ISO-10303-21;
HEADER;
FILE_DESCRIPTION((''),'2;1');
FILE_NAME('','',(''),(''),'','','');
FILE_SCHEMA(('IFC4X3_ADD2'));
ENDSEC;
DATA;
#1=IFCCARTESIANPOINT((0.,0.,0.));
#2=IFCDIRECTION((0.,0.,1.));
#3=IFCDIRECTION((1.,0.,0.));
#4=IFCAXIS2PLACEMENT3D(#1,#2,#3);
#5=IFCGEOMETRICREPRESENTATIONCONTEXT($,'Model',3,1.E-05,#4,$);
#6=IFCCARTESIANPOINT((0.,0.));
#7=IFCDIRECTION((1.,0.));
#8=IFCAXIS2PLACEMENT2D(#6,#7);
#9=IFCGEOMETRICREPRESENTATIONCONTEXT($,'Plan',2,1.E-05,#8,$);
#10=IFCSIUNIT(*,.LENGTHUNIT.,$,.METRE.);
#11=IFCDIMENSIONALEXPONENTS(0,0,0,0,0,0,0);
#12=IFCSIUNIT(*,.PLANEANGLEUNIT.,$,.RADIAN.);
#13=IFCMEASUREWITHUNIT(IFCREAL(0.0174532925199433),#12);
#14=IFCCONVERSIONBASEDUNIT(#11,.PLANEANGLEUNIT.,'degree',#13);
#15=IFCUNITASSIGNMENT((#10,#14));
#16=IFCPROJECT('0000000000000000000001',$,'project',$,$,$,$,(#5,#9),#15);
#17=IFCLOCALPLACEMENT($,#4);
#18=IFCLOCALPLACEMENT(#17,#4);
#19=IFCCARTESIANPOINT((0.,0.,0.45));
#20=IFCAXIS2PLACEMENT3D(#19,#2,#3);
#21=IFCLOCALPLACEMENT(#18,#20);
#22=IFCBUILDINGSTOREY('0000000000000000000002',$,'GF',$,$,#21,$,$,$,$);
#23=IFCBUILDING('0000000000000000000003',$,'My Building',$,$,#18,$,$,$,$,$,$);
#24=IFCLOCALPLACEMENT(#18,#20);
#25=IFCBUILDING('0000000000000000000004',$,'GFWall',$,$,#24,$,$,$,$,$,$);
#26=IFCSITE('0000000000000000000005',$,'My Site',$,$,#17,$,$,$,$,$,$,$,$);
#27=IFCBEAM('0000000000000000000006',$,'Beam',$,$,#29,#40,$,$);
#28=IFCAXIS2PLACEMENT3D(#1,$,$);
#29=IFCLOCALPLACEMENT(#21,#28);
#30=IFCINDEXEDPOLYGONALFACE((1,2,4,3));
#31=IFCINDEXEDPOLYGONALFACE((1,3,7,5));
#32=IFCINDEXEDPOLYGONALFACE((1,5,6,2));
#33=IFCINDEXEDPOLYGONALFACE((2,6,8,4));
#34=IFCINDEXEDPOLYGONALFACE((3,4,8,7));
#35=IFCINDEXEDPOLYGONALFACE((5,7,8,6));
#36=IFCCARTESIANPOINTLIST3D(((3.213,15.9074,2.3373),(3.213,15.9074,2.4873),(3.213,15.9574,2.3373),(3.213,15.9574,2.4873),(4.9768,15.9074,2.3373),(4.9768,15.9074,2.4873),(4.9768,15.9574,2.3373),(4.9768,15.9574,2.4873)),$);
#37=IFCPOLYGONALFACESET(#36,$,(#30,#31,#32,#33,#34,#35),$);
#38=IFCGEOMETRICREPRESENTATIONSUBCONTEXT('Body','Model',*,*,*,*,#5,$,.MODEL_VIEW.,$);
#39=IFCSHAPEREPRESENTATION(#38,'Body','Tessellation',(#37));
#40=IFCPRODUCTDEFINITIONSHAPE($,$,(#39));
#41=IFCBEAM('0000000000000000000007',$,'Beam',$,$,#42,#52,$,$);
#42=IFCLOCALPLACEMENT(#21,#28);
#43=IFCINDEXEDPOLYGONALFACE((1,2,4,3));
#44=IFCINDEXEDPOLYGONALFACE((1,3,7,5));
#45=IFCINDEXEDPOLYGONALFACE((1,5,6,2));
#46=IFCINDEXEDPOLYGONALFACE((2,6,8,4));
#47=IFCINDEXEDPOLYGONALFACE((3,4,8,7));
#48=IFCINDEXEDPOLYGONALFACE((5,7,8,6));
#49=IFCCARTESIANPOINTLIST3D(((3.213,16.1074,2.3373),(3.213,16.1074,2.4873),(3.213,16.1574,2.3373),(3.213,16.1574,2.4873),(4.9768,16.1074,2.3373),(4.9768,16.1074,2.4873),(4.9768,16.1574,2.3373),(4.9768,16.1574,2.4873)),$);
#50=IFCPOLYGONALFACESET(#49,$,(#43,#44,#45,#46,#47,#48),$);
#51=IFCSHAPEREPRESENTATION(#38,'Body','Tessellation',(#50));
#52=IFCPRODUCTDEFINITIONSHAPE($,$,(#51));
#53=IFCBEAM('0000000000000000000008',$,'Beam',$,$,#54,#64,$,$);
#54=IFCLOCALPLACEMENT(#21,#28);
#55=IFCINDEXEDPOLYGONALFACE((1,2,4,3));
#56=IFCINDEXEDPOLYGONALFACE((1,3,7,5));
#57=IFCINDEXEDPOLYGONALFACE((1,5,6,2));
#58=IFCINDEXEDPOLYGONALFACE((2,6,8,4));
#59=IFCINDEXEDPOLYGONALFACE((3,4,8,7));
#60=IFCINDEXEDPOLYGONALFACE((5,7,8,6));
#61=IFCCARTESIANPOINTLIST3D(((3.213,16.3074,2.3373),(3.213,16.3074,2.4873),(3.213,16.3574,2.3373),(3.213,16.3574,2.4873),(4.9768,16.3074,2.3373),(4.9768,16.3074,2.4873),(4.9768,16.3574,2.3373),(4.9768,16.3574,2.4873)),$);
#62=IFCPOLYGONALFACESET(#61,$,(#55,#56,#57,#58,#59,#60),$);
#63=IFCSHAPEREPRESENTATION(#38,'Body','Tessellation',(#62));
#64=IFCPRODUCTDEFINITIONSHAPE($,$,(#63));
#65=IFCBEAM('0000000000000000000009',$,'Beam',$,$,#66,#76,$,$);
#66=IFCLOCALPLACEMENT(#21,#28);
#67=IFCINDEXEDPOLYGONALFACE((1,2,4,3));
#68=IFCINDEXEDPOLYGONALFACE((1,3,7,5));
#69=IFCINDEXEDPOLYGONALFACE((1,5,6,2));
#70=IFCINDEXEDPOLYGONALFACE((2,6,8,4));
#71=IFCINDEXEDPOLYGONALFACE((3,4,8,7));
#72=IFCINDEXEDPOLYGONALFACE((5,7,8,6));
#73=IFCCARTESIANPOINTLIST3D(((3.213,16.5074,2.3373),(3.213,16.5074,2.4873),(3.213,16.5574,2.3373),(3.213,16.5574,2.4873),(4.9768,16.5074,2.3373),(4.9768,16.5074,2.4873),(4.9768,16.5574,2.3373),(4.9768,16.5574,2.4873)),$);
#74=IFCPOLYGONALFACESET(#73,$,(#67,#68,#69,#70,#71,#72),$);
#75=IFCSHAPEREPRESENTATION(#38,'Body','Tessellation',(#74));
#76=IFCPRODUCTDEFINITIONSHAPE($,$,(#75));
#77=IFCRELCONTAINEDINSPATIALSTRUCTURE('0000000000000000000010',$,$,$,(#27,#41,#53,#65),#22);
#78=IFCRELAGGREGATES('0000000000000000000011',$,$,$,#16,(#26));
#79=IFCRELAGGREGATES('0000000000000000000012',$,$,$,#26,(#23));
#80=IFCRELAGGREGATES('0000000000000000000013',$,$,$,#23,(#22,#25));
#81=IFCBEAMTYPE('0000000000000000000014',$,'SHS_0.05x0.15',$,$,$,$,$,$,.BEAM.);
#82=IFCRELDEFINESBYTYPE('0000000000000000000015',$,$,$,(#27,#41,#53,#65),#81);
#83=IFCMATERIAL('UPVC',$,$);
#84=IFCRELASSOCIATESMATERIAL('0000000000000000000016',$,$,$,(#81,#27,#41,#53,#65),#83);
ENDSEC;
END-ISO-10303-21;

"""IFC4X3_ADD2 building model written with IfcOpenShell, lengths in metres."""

from ifc_helpers import new_model, entity, si_unit, converted_unit, frame, origin_with_axes, origin_2d_with_axis, place, context, subcontext, project, spatial, rectangle, extrude, material, material_profile, profile_set, profile_usage, type_object, element, save


model = new_model("IFC4X3_ADD2")

# Units and contexts
model_context = context("Model", 3, precision=1e-05, world=origin_with_axes())
plan_context = context("Plan", 2, precision=1e-05, world=origin_2d_with_axis())
body_context_1 = subcontext(model_context, "Body", "Model", "MODEL_VIEW")
ifc_project = project(units=[si_unit("LENGTHUNIT", "METRE"), converted_unit("PLANEANGLEUNIT", "degree", entity("IfcReal", 0.0174532925199433), si_unit("PLANEANGLEUNIT", "RADIAN"), dimensions=[0, 0, 0, 0, 0, 0, 0])], contexts=[model_context, plan_context])

# Site, building, storey
site_placement = place(None, origin_with_axes())
site = spatial("IfcSite", under=ifc_project, at=site_placement, Name="My Site")
building_1_placement = place(site_placement, origin_with_axes())
building_1 = spatial("IfcBuilding", under=site, at=building_1_placement, Name="My Building")
storey_placement = place(building_1_placement, frame((0.0, 0.0, 0.45), z_axis=(0.0, 0.0, 1.0), x_axis=(1.0, 0.0, 0.0)))
storey = spatial("IfcBuildingStorey", under=building_1, at=storey_placement, Name="GF")

# Beams
ifc_material_1 = material(Name="UPVC")
ifc_material_profile_1 = material_profile(ifc_material_1, rectangle(XDim=0.05, YDim=0.15))
ifc_profile_set_1 = profile_set([ifc_material_profile_1])
beam_type_1 = type_object("IfcBeamType", Name="SHS_0.05x0.15", PredefinedType="BEAM", material=ifc_profile_set_1)
ifc_profile_usage_1 = profile_usage(ifc_profile_set_1)
beam_1_placement = place(storey_placement, frame((3.213, 15.9324, 2.4123), z_axis=(1.0, 0.0, 0.0), x_axis=(0.0, 1.0, 0.0)))
element("IfcBeam", 1, at=beam_1_placement, inside=storey, type_object=beam_type_1, material=ifc_profile_usage_1, Name="Beam", context=body_context_1, shape_type="SweptSolid", body=[
    extrude(rectangle(XDim=0.05, YDim=0.15), origin_with_axes(), (0.0, 0.0, 1.0), 1.7638),
])
ifc_profile_usage_2 = profile_usage(ifc_profile_set_1)
beam_2_placement = place(storey_placement, frame((3.213, 16.1324, 2.4123), z_axis=(1.0, 0.0, 0.0), x_axis=(0.0, 1.0, 0.0)))
element("IfcBeam", 2, at=beam_2_placement, inside=storey, type_object=beam_type_1, material=ifc_profile_usage_2, Name="Beam", context=body_context_1, shape_type="SweptSolid", body=[
    extrude(rectangle(XDim=0.05, YDim=0.15), origin_with_axes(), (0.0, 0.0, 1.0), 1.7638),
])
ifc_profile_usage_3 = profile_usage(ifc_profile_set_1)
beam_3_placement = place(storey_placement, frame((3.213, 16.3324, 2.4123), z_axis=(1.0, 0.0, 0.0), x_axis=(0.0, 1.0, 0.0)))
element("IfcBeam", 3, at=beam_3_placement, inside=storey, type_object=beam_type_1, material=ifc_profile_usage_3, Name="Beam", context=body_context_1, shape_type="SweptSolid", body=[
    extrude(rectangle(XDim=0.05, YDim=0.15), origin_with_axes(), (0.0, 0.0, 1.0), 1.7638),
])
ifc_profile_usage_4 = profile_usage(ifc_profile_set_1)
beam_4_placement = place(storey_placement, frame((3.213, 16.5324, 2.4123), z_axis=(1.0, 0.0, 0.0), x_axis=(0.0, 1.0, 0.0)))
element("IfcBeam", 4, at=beam_4_placement, inside=storey, type_object=beam_type_1, material=ifc_profile_usage_4, Name="Beam", context=body_context_1, shape_type="SweptSolid", body=[
    extrude(rectangle(XDim=0.05, YDim=0.15), origin_with_axes(), (0.0, 0.0, 1.0), 1.7638),
])

# Shared definitions
building_2_placement = place(building_1_placement, frame((0.0, 0.0, 0.45), z_axis=(0.0, 0.0, 1.0), x_axis=(1.0, 0.0, 0.0)))
building_2 = spatial("IfcBuilding", under=building_1, at=building_2_placement, Name="GFWall")

save(model, "model.ifc")
